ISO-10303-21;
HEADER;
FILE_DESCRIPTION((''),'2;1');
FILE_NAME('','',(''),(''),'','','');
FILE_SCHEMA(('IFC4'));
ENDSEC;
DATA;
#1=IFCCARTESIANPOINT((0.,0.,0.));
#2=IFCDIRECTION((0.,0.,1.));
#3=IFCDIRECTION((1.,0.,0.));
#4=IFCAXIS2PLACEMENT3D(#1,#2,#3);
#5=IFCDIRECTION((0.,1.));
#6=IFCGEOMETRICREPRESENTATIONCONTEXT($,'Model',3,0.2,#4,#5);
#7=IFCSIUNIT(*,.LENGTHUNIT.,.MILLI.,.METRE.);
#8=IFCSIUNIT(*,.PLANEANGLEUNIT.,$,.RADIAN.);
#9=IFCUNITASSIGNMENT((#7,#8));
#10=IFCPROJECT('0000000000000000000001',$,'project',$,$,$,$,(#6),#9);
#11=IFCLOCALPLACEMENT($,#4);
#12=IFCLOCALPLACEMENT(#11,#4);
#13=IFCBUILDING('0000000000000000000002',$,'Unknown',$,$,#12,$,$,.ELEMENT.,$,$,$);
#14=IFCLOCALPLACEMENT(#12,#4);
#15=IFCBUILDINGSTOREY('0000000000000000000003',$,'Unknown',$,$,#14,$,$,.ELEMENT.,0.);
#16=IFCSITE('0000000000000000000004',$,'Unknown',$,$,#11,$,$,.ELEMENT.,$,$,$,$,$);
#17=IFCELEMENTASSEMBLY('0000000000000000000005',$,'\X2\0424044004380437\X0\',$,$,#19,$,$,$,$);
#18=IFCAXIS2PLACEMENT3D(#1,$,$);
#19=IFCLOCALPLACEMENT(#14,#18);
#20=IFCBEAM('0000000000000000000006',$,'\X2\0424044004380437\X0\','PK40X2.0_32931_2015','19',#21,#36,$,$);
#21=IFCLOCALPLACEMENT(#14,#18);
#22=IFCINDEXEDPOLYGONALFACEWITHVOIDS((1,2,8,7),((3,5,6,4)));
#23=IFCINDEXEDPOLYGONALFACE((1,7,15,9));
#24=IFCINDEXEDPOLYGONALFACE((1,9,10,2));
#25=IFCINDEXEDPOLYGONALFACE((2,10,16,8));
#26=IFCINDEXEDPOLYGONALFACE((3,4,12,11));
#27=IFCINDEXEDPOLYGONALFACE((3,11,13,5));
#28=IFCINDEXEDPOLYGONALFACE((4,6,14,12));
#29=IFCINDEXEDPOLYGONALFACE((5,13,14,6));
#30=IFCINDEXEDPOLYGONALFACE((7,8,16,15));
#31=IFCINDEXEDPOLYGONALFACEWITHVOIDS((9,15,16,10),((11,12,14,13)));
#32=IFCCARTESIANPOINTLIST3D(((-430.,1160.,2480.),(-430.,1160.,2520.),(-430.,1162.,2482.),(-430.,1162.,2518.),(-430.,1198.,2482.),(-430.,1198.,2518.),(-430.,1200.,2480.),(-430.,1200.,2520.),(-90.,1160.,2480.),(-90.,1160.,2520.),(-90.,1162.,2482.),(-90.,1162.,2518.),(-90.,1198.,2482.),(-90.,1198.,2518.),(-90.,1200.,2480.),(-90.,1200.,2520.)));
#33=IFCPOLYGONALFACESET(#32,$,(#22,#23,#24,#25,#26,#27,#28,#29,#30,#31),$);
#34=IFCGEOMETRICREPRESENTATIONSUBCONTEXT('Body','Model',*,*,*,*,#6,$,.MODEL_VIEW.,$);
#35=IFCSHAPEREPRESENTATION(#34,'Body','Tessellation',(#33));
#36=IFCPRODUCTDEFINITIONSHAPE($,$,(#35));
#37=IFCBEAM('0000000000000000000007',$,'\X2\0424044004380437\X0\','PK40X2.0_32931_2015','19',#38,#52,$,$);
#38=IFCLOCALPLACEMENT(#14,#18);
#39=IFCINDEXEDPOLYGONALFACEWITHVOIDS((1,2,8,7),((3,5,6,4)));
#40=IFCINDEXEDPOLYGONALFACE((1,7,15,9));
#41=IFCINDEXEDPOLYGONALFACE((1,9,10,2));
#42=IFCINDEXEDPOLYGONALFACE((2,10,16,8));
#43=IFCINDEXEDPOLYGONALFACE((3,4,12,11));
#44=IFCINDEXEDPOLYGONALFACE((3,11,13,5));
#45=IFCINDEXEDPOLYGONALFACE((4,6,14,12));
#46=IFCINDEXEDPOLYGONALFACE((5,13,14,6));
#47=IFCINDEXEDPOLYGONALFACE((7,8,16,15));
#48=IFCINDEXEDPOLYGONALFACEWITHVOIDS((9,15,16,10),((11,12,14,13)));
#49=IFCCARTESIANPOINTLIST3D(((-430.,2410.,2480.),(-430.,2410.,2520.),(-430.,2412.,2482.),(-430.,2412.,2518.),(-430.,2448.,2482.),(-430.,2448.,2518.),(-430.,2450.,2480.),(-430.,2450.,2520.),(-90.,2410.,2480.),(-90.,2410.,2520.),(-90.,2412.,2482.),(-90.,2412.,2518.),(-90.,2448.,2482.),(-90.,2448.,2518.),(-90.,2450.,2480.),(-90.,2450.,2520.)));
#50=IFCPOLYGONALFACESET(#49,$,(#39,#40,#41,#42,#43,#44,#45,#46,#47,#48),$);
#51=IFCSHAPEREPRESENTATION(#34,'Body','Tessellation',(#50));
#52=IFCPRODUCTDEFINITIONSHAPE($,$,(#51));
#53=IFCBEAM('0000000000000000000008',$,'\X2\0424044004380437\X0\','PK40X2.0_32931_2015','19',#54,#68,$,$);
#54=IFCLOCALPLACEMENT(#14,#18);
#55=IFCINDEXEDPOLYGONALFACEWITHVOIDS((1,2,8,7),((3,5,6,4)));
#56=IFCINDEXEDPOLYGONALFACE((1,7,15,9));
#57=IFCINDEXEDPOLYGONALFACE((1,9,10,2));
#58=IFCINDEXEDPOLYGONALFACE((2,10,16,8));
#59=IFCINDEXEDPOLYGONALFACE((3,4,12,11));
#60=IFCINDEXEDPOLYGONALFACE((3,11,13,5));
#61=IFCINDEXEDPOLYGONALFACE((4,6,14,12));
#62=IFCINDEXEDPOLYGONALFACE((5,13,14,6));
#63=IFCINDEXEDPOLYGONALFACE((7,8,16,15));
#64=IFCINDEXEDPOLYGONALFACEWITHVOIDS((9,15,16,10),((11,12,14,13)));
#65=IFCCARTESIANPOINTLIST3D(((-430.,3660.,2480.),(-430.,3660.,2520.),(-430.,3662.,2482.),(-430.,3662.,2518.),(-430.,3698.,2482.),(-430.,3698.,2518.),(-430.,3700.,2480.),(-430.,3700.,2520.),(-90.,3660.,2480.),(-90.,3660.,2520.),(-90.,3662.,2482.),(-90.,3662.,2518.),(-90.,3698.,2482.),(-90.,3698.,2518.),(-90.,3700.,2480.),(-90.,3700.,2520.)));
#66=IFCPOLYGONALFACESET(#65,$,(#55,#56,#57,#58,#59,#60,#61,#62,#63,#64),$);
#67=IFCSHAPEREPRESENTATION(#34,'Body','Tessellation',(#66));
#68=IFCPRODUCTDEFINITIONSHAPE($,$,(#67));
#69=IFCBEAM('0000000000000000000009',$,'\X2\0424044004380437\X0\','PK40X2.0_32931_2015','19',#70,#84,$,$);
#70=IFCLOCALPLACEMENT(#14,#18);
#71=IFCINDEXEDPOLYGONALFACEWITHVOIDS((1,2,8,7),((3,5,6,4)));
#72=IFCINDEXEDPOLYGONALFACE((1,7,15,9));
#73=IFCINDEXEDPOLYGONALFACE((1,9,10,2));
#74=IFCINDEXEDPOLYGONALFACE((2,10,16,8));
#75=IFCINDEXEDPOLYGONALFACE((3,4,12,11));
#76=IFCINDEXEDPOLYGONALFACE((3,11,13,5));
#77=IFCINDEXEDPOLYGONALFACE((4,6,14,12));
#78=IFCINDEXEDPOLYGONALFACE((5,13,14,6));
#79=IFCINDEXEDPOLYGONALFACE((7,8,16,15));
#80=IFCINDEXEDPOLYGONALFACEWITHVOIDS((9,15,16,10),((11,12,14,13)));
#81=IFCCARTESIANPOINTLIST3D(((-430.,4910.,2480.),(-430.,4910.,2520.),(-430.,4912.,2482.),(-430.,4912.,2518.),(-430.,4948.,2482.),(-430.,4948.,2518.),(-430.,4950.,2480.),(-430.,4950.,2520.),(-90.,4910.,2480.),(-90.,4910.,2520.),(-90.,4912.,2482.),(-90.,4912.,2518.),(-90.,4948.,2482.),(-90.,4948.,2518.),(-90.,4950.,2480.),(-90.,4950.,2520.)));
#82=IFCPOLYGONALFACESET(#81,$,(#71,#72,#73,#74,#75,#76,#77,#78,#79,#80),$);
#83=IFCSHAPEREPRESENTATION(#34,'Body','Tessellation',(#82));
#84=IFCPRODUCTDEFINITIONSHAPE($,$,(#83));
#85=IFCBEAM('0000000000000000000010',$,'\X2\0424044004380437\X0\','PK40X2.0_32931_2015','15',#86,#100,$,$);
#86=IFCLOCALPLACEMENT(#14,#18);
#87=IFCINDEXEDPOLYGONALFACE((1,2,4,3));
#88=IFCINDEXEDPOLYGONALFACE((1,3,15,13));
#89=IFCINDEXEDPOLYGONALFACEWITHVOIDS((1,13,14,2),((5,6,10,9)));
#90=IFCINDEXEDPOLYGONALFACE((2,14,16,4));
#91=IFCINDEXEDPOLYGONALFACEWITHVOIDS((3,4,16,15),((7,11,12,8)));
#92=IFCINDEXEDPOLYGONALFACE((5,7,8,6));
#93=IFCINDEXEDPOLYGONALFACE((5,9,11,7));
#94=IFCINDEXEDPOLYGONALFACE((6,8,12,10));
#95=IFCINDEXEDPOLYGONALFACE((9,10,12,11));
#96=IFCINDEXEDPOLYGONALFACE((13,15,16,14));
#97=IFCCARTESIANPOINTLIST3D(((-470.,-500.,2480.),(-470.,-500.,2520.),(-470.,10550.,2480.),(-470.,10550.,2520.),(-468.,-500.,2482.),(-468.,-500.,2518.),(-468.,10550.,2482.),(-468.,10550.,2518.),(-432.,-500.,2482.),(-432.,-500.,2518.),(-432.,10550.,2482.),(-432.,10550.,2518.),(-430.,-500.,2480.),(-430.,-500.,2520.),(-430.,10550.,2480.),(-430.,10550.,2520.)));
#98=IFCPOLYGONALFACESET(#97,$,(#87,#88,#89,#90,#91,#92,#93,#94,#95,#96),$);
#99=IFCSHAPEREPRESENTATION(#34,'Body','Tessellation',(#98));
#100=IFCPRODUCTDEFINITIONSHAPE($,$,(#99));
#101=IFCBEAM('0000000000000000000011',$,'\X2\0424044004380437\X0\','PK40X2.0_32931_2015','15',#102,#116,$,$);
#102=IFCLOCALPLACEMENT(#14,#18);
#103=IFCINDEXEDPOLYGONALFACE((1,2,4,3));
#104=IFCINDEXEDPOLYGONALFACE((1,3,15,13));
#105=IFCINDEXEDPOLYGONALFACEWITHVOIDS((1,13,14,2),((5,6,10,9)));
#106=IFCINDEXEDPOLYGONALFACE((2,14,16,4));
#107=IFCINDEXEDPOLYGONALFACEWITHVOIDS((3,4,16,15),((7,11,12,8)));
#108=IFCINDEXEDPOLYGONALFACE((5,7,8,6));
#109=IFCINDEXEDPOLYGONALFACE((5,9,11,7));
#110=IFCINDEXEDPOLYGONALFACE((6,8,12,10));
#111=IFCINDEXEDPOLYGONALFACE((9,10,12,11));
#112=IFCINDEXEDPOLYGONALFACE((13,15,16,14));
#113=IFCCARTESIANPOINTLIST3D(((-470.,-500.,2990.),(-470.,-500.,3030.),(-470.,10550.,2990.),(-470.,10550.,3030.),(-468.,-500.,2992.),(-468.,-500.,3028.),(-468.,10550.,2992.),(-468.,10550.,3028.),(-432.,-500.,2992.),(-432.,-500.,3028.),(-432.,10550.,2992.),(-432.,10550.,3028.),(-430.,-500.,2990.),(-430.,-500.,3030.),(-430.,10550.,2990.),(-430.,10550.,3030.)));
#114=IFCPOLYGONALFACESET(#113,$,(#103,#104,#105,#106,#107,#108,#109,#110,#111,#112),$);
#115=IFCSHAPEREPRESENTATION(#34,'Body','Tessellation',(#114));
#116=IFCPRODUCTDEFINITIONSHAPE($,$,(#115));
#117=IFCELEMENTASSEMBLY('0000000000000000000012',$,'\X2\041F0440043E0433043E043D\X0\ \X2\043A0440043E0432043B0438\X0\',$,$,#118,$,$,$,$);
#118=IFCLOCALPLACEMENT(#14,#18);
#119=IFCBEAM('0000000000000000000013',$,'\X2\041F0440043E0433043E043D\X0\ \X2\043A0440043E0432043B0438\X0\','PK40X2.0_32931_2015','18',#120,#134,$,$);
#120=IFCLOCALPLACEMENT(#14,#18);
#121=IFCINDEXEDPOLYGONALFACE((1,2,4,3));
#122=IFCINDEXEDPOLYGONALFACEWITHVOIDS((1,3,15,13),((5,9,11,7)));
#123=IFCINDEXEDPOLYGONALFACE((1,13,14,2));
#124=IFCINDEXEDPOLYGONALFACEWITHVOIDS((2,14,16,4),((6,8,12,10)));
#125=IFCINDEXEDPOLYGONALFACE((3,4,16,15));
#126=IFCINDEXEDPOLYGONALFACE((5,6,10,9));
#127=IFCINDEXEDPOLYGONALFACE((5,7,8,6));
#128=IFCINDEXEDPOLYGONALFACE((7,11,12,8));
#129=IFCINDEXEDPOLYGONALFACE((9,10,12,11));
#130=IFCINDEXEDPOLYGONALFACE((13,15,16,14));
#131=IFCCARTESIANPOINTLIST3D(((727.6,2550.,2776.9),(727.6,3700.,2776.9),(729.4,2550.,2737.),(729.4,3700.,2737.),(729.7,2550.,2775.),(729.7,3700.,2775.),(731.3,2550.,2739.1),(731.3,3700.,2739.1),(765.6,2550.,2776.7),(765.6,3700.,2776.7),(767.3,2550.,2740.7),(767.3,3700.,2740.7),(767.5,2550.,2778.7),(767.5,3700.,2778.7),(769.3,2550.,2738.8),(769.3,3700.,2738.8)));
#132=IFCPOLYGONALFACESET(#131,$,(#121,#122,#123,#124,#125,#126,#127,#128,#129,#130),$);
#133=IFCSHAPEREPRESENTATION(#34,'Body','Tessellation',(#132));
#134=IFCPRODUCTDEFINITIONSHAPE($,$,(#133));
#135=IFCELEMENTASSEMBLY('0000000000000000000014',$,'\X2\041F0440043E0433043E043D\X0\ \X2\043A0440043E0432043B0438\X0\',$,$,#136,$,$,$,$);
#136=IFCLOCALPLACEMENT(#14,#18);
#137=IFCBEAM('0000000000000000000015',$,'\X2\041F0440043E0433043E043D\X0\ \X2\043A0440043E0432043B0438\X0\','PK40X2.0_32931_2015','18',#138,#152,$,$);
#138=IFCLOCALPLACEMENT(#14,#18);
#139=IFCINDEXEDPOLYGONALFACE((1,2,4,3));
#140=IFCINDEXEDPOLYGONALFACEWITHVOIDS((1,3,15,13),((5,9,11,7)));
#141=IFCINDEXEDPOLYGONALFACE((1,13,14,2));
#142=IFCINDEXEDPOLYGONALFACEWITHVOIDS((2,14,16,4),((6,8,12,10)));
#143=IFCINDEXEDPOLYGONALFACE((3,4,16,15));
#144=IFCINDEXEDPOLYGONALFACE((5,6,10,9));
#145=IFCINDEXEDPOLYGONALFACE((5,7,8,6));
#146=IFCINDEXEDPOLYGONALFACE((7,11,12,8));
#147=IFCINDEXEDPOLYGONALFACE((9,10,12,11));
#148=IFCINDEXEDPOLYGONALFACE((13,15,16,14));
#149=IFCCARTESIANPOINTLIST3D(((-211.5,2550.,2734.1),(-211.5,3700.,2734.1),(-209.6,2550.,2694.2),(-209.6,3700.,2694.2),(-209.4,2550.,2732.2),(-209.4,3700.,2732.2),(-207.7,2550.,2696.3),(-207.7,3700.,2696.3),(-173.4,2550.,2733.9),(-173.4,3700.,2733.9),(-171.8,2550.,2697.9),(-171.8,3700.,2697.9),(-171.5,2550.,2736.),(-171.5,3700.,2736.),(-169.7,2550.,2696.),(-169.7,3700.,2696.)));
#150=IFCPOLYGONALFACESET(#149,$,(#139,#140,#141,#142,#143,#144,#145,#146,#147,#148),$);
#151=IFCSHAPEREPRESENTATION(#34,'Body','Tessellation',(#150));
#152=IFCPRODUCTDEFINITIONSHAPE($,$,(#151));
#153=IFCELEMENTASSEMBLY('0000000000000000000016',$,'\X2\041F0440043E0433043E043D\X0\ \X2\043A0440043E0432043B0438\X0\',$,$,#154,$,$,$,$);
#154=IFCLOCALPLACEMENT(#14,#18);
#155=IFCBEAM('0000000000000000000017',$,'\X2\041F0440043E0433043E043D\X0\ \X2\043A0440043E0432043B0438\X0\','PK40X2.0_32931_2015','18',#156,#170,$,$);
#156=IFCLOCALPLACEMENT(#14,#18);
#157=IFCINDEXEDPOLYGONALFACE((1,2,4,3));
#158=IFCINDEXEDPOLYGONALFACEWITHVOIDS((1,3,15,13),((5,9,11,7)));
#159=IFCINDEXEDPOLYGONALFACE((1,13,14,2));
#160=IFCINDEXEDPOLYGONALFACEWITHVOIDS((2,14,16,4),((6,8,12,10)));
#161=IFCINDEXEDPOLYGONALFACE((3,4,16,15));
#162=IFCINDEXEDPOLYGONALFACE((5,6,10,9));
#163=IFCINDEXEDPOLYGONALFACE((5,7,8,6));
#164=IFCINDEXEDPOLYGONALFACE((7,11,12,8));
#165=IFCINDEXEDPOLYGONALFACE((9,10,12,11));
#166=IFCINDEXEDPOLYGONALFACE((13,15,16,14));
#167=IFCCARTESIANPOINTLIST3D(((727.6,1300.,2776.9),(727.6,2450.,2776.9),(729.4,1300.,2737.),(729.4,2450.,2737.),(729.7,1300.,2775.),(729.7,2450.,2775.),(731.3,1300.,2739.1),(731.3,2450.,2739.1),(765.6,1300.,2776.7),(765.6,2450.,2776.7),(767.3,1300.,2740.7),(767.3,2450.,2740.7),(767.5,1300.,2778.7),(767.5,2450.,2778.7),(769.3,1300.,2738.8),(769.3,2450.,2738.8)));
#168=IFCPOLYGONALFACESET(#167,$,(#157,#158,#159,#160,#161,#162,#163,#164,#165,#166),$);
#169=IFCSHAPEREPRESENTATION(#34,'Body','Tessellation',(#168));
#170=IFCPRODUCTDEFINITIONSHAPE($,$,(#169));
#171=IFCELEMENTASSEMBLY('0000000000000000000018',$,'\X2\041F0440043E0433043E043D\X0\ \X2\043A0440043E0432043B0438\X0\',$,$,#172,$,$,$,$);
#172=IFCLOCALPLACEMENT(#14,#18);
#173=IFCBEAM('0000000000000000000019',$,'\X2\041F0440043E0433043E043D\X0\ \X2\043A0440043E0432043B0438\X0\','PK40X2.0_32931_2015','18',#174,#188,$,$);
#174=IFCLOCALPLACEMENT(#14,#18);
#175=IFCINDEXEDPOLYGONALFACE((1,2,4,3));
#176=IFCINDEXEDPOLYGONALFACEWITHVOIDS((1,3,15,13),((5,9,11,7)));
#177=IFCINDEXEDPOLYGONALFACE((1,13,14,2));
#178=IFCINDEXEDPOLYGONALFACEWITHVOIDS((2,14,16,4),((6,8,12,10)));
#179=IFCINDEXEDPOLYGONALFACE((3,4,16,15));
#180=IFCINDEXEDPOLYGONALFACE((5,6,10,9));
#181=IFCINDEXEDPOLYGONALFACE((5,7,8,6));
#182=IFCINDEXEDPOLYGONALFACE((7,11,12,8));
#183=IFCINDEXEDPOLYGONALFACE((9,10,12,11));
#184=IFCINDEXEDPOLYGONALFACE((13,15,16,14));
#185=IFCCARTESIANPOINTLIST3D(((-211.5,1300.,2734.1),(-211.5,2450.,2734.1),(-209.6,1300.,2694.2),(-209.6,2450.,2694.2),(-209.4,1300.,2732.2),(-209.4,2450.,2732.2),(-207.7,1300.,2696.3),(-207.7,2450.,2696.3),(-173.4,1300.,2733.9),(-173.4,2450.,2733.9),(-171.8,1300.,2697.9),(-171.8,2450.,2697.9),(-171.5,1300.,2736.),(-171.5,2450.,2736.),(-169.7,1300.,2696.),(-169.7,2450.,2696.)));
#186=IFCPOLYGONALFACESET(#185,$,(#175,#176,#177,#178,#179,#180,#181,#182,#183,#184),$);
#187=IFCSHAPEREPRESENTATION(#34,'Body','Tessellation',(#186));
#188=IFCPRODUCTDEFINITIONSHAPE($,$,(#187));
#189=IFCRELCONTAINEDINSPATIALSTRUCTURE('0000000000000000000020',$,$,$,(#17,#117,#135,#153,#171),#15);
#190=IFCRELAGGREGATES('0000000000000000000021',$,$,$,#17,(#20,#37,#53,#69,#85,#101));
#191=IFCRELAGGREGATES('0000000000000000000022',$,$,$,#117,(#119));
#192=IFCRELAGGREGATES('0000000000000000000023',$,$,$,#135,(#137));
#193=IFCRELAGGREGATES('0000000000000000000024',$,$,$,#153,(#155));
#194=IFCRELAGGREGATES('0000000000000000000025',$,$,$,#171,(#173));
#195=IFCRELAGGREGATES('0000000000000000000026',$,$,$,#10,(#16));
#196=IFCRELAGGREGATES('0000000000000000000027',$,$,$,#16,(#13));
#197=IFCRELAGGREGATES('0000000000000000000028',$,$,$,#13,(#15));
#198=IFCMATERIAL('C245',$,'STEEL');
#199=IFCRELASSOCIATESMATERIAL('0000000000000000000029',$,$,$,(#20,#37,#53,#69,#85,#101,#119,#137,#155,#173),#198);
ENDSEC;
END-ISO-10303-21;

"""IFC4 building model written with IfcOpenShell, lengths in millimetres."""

from ifc_helpers import new_model, si_unit, direction, frame, origin_with_axes, place, context, subcontext, project, spatial, line, indexed_curve, outline, extrude, material, element, aggregate, save


model = new_model("IFC4")

# Units and contexts
model_context = context("Model", 3, precision=0.2, world=origin_with_axes(), true_north=direction((0.0, 1.0)))
body_context = subcontext(model_context, "Body", "Model", "MODEL_VIEW")
ifc_project = project(units=[si_unit("LENGTHUNIT", "METRE", prefix="MILLI"), si_unit("PLANEANGLEUNIT", "RADIAN")], contexts=[model_context])

# Site, building, storey
site_placement = place(None, origin_with_axes())
site = spatial("IfcSite", under=ifc_project, at=site_placement, Name="Unknown", CompositionType="ELEMENT")
building_placement = place(site_placement, origin_with_axes())
building = spatial("IfcBuilding", under=site, at=building_placement, Name="Unknown", CompositionType="ELEMENT")
storey_placement = place(building_placement, origin_with_axes())
storey = spatial("IfcBuildingStorey", under=building, at=storey_placement, Name="Unknown", CompositionType="ELEMENT", Elevation=0.0)

# Shared definitions
ifc_material = material(Name="C245", Category="STEEL")

# Element assembly
assembly_1_placement = place(storey_placement, frame((-450.0, -500.0, 3010.0), z_axis=(1.0, 0.0, 0.0), x_axis=(0.0, 1.0, 0.0)))
assembly_1 = element("IfcElementAssembly", 1, at=assembly_1_placement, inside=storey, Name="Фриз")

# Beams
beam_1_placement = place(assembly_1_placement, frame((1680.0, -510.0, 20.0), z_axis=(-1.0, 0.0, 0.0), x_axis=(0.0, 0.0, 1.0)))
beam_1 = element("IfcBeam", 2, at=beam_1_placement, material=ifc_material, Name="Фриз", Description="PK40X2.0_32931_2015", ObjectType="19", context=body_context, shape_type="SolidModel", body=[
    extrude(outline(indexed_curve([(-20.0, -20.0), (20.0, -20.0), (20.0, 20.0), (-20.0, 20.0)], segments=[line(1, 2, 3, 4, 1)]), holes=[indexed_curve([(-18.0, -18.0), (-18.0, 18.0), (18.0, 18.0), (18.0, -18.0)], segments=[line(1, 2, 3, 4, 1)])]), frame((0.0, 0.0, 0.0), z_axis=(-1.0, 0.0, 0.0), x_axis=(0.0, 0.0, 1.0)), (0.0, 0.0, -1.0), 340.0),
])
beam_2_placement = place(assembly_1_placement, frame((2930.0, -510.0, 20.0), z_axis=(-1.0, 0.0, 0.0), x_axis=(0.0, 0.0, 1.0)))
beam_2 = element("IfcBeam", 3, at=beam_2_placement, material=ifc_material, Name="Фриз", Description="PK40X2.0_32931_2015", ObjectType="19", context=body_context, shape_type="SolidModel", body=[
    extrude(outline(indexed_curve([(-20.0, -20.0), (20.0, -20.0), (20.0, 20.0), (-20.0, 20.0)], segments=[line(1, 2, 3, 4, 1)]), holes=[indexed_curve([(-18.0, -18.0), (-18.0, 18.0), (18.0, 18.0), (18.0, -18.0)], segments=[line(1, 2, 3, 4, 1)])]), frame((0.0, 0.0, 0.0), z_axis=(-1.0, 0.0, 0.0), x_axis=(0.0, 0.0, 1.0)), (0.0, 0.0, -1.0), 340.0),
])
beam_3_placement = place(assembly_1_placement, frame((4180.0, -510.0, 20.0), z_axis=(-1.0, 0.0, 0.0), x_axis=(0.0, 0.0, 1.0)))
beam_3 = element("IfcBeam", 4, at=beam_3_placement, material=ifc_material, Name="Фриз", Description="PK40X2.0_32931_2015", ObjectType="19", context=body_context, shape_type="SolidModel", body=[
    extrude(outline(indexed_curve([(-20.0, -20.0), (20.0, -20.0), (20.0, 20.0), (-20.0, 20.0)], segments=[line(1, 2, 3, 4, 1)]), holes=[indexed_curve([(-18.0, -18.0), (-18.0, 18.0), (18.0, 18.0), (18.0, -18.0)], segments=[line(1, 2, 3, 4, 1)])]), frame((0.0, 0.0, 0.0), z_axis=(-1.0, 0.0, 0.0), x_axis=(0.0, 0.0, 1.0)), (0.0, 0.0, -1.0), 340.0),
])
beam_4_placement = place(assembly_1_placement, frame((5430.0, -510.0, 20.0), z_axis=(-1.0, 0.0, 0.0), x_axis=(0.0, 0.0, 1.0)))
beam_4 = element("IfcBeam", 5, at=beam_4_placement, material=ifc_material, Name="Фриз", Description="PK40X2.0_32931_2015", ObjectType="19", context=body_context, shape_type="SolidModel", body=[
    extrude(outline(indexed_curve([(-20.0, -20.0), (20.0, -20.0), (20.0, 20.0), (-20.0, 20.0)], segments=[line(1, 2, 3, 4, 1)]), holes=[indexed_curve([(-18.0, -18.0), (-18.0, 18.0), (18.0, 18.0), (18.0, -18.0)], segments=[line(1, 2, 3, 4, 1)])]), frame((0.0, 0.0, 0.0), z_axis=(-1.0, 0.0, 0.0), x_axis=(0.0, 0.0, 1.0)), (0.0, 0.0, -1.0), 340.0),
])
beam_5_placement = place(assembly_1_placement, frame((0.0, -510.0, 0.0), z_axis=(0.0, 0.0, 1.0), x_axis=(1.0, 0.0, 0.0)))
beam_5 = element("IfcBeam", 6, at=beam_5_placement, material=ifc_material, Name="Фриз", Description="PK40X2.0_32931_2015", ObjectType="15", context=body_context, shape_type="SolidModel", body=[
    extrude(outline(indexed_curve([(-20.0, -20.0), (20.0, -20.0), (20.0, 20.0), (-20.0, 20.0)], segments=[line(1, 2, 3, 4, 1)]), holes=[indexed_curve([(-18.0, -18.0), (-18.0, 18.0), (18.0, 18.0), (18.0, -18.0)], segments=[line(1, 2, 3, 4, 1)])]), frame((0.0, 0.0, 0.0), z_axis=(-1.0, 0.0, 0.0), x_axis=(0.0, 0.0, 1.0)), (0.0, 0.0, -1.0), 11050.0),
])
beam_6_placement = place(assembly_1_placement, origin_with_axes())
beam_6 = element("IfcBeam", 7, at=beam_6_placement, material=ifc_material, Name="Фриз", Description="PK40X2.0_32931_2015", ObjectType="15", context=body_context, shape_type="SolidModel", body=[
    extrude(outline(indexed_curve([(-20.0, -20.0), (20.0, -20.0), (20.0, 20.0), (-20.0, 20.0)], segments=[line(1, 2, 3, 4, 1)]), holes=[indexed_curve([(-18.0, -18.0), (-18.0, 18.0), (18.0, 18.0), (18.0, -18.0)], segments=[line(1, 2, 3, 4, 1)])]), frame((0.0, 0.0, 0.0), z_axis=(-1.0, 0.0, 0.0), x_axis=(0.0, 0.0, 1.0)), (0.0, 0.0, -1.0), 11050.0),
])
aggregate(assembly_1, [beam_1, beam_2, beam_3, beam_4, beam_5, beam_6])

# Element assemblies, beams
assembly_2_placement = place(storey_placement, frame((748.5, 3700.0, 2757.9), z_axis=(-0.998964, 0.0, -0.045508), x_axis=(0.0, -1.0, 0.0)))
assembly_2 = element("IfcElementAssembly", 8, at=assembly_2_placement, inside=storey, Name="Прогон кровли")
beam_7_placement = place(assembly_2_placement, origin_with_axes())
beam_7 = element("IfcBeam", 9, at=beam_7_placement, material=ifc_material, Name="Прогон кровли", Description="PK40X2.0_32931_2015", ObjectType="18", context=body_context, shape_type="SolidModel", body=[
    extrude(outline(indexed_curve([(-20.0, -20.0), (20.0, -20.0), (20.0, 20.0), (-20.0, 20.0)], segments=[line(1, 2, 3, 4, 1)]), holes=[indexed_curve([(-18.0, -18.0), (-18.0, 18.0), (18.0, 18.0), (18.0, -18.0)], segments=[line(1, 2, 3, 4, 1)])]), frame((0.0, 0.0, 0.0), z_axis=(-1.0, 0.0, 0.0), x_axis=(0.0, 0.0, 1.0)), (0.0, 0.0, -1.0), 1150.0),
])
aggregate(assembly_2, [beam_7])
assembly_3_placement = place(storey_placement, frame((-190.6, 3700.0, 2715.1), z_axis=(-0.998964, 0.0, -0.045508), x_axis=(0.0, -1.0, 0.0)))
assembly_3 = element("IfcElementAssembly", 10, at=assembly_3_placement, inside=storey, Name="Прогон кровли")
beam_8_placement = place(assembly_3_placement, origin_with_axes())
beam_8 = element("IfcBeam", 11, at=beam_8_placement, material=ifc_material, Name="Прогон кровли", Description="PK40X2.0_32931_2015", ObjectType="18", context=body_context, shape_type="SolidModel", body=[
    extrude(outline(indexed_curve([(-20.0, -20.0), (20.0, -20.0), (20.0, 20.0), (-20.0, 20.0)], segments=[line(1, 2, 3, 4, 1)]), holes=[indexed_curve([(-18.0, -18.0), (-18.0, 18.0), (18.0, 18.0), (18.0, -18.0)], segments=[line(1, 2, 3, 4, 1)])]), frame((0.0, 0.0, 0.0), z_axis=(-1.0, 0.0, 0.0), x_axis=(0.0, 0.0, 1.0)), (0.0, 0.0, -1.0), 1150.0),
])
aggregate(assembly_3, [beam_8])
assembly_4_placement = place(storey_placement, frame((748.5, 2450.0, 2757.9), z_axis=(-0.998964, 0.0, -0.045508), x_axis=(0.0, -1.0, 0.0)))
assembly_4 = element("IfcElementAssembly", 12, at=assembly_4_placement, inside=storey, Name="Прогон кровли")
beam_9_placement = place(assembly_4_placement, origin_with_axes())
beam_9 = element("IfcBeam", 13, at=beam_9_placement, material=ifc_material, Name="Прогон кровли", Description="PK40X2.0_32931_2015", ObjectType="18", context=body_context, shape_type="SolidModel", body=[
    extrude(outline(indexed_curve([(-20.0, -20.0), (20.0, -20.0), (20.0, 20.0), (-20.0, 20.0)], segments=[line(1, 2, 3, 4, 1)]), holes=[indexed_curve([(-18.0, -18.0), (-18.0, 18.0), (18.0, 18.0), (18.0, -18.0)], segments=[line(1, 2, 3, 4, 1)])]), frame((0.0, 0.0, 0.0), z_axis=(-1.0, 0.0, 0.0), x_axis=(0.0, 0.0, 1.0)), (0.0, 0.0, -1.0), 1150.0),
])
aggregate(assembly_4, [beam_9])
assembly_5_placement = place(storey_placement, frame((-190.6, 2450.0, 2715.1), z_axis=(-0.998964, 0.0, -0.045508), x_axis=(0.0, -1.0, 0.0)))
assembly_5 = element("IfcElementAssembly", 14, at=assembly_5_placement, inside=storey, Name="Прогон кровли")
beam_10_placement = place(assembly_5_placement, origin_with_axes())
beam_10 = element("IfcBeam", 15, at=beam_10_placement, material=ifc_material, Name="Прогон кровли", Description="PK40X2.0_32931_2015", ObjectType="18", context=body_context, shape_type="SolidModel", body=[
    extrude(outline(indexed_curve([(-20.0, -20.0), (20.0, -20.0), (20.0, 20.0), (-20.0, 20.0)], segments=[line(1, 2, 3, 4, 1)]), holes=[indexed_curve([(-18.0, -18.0), (-18.0, 18.0), (18.0, 18.0), (18.0, -18.0)], segments=[line(1, 2, 3, 4, 1)])]), frame((0.0, 0.0, 0.0), z_axis=(-1.0, 0.0, 0.0), x_axis=(0.0, 0.0, 1.0)), (0.0, 0.0, -1.0), 1150.0),
])
aggregate(assembly_5, [beam_10])

save(model, "model.ifc")
